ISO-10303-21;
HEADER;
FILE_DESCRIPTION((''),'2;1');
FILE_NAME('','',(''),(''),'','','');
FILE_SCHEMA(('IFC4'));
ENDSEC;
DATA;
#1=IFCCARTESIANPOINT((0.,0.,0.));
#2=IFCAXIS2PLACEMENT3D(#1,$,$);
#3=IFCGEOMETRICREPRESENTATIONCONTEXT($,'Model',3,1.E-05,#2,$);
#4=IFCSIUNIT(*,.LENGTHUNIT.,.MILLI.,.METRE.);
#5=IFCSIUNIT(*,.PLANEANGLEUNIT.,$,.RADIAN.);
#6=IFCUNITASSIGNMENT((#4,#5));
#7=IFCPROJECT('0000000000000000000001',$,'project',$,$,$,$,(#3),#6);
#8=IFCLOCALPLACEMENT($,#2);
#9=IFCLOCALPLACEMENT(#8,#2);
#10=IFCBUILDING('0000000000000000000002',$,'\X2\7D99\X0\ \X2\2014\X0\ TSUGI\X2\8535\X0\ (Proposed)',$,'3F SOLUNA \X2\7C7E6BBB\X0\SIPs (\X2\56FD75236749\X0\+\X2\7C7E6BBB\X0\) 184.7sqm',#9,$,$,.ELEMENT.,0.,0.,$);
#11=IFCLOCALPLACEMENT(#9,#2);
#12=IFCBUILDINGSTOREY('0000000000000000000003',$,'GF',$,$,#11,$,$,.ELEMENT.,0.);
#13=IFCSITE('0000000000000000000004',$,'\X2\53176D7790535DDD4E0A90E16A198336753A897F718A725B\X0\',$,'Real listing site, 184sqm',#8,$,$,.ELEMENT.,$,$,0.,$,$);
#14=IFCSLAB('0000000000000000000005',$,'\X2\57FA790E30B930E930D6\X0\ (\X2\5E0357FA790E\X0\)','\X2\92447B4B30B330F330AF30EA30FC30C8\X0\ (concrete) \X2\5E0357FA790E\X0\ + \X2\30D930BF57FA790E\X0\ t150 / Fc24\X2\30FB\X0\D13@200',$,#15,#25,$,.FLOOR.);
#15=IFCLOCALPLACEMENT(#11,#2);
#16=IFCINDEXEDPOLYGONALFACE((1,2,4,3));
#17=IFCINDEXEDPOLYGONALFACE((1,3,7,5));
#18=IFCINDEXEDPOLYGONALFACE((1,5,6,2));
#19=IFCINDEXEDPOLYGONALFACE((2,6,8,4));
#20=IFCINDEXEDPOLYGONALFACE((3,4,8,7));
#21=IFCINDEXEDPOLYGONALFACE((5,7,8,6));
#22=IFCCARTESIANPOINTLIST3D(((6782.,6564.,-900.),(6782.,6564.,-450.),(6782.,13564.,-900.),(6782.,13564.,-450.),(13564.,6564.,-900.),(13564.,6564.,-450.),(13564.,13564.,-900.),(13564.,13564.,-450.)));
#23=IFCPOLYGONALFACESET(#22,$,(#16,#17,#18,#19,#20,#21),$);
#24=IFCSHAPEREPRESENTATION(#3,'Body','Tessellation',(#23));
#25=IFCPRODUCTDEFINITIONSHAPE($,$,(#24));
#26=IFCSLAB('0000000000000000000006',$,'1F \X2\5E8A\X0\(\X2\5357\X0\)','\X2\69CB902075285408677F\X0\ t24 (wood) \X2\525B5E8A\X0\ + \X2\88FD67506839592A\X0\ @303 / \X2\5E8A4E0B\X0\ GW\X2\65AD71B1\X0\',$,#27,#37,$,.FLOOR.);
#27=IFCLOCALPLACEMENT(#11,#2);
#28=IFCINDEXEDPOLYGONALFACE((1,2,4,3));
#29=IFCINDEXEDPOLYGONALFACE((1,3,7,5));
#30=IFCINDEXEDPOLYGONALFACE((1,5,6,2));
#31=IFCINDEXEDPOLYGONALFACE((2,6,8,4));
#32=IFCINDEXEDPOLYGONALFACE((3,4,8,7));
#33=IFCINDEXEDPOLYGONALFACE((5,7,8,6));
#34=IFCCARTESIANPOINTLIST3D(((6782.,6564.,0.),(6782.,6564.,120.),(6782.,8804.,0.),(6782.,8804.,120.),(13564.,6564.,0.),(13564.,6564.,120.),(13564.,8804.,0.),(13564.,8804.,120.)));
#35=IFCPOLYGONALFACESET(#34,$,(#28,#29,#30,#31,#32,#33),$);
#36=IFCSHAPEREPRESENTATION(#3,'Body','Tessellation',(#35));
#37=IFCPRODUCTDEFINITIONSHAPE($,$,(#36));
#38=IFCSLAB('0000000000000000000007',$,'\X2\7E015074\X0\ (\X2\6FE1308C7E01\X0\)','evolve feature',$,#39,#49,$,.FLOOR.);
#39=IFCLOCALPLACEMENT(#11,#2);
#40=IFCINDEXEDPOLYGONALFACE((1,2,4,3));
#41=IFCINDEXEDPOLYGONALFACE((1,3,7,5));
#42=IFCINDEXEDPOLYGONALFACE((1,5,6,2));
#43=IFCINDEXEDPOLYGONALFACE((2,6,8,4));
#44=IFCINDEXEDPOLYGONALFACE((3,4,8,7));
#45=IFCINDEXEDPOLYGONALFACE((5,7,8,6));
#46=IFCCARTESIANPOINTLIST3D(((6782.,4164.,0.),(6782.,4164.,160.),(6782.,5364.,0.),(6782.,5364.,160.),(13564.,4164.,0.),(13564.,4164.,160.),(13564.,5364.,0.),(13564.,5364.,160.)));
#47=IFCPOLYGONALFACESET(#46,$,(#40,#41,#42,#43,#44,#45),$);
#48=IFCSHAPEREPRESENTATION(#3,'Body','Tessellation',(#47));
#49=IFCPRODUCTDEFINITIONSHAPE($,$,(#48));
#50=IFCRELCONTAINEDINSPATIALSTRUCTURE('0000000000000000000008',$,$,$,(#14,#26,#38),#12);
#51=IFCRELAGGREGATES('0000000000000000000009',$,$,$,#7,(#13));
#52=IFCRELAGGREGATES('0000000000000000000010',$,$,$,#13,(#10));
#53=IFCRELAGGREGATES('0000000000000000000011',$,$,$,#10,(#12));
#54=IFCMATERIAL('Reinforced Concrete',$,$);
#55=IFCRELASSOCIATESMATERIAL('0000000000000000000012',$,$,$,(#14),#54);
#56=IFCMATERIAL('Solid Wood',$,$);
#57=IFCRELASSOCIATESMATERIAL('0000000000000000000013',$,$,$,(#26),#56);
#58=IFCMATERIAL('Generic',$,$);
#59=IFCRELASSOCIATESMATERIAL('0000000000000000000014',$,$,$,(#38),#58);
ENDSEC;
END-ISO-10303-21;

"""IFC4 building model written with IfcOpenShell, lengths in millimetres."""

from ifc_helpers import new_model, si_unit, frame, frame_2d, origin, place, context, project, spatial, rectangle, extrude, material, element, save


model = new_model("IFC4")

# Units and contexts
model_context = context("Model", 3, precision=1e-05, world=origin())
ifc_project = project(units=[si_unit("LENGTHUNIT", "METRE", prefix="MILLI"), si_unit("PLANEANGLEUNIT", "RADIAN")], contexts=[model_context])

# Site, building, storey
site_placement = place(None, origin())
site = spatial("IfcSite", under=ifc_project, at=site_placement, Name="北海道川上郡標茶町西熊牛", ObjectType="Real listing site, 184sqm", CompositionType="ELEMENT", RefElevation=0.0)
building_placement = place(site_placement, origin())
building = spatial("IfcBuilding", under=site, at=building_placement, Name="継 — TSUGI蔵 (Proposed)", ObjectType="3F SOLUNA 籾殻SIPs (国産杉+籾殻) 184.7sqm", CompositionType="ELEMENT", ElevationOfRefHeight=0.0, ElevationOfTerrain=0.0)
storey_placement = place(building_placement, origin())
storey = spatial("IfcBuildingStorey", under=building, at=storey_placement, Name="GF", CompositionType="ELEMENT", Elevation=0.0)

# Slabs
ifc_material_1 = material(Name="Reinforced Concrete")
slab_1_placement = place(storey_placement, frame((3391.0, 3282.0, -450.0)))
element("IfcSlab", 1, at=slab_1_placement, inside=storey, material=ifc_material_1, Name="基礎スラブ (布基礎)", Description="鉄筋コンクリート (concrete) 布基礎 + ベタ基礎 t150 / Fc24・D13@200", PredefinedType="FLOOR", context=model_context, shape_type="SweptSolid", body=[
    extrude(rectangle(XDim=6782.0, YDim=7000.0, at=frame_2d((3391.0, 3500.0))), frame((3391.0, 3282.0, -450.0)), (0.0, 0.0, 1.0), 450.0),
])
ifc_material_2 = material(Name="Solid Wood")
slab_2_placement = place(storey_placement, frame((3391.0, 3282.0, 0.0)))
element("IfcSlab", 2, at=slab_2_placement, inside=storey, material=ifc_material_2, Name="1F 床(南)", Description="構造用合板 t24 (wood) 剛床 + 製材根太 @303 / 床下 GW断熱", PredefinedType="FLOOR", context=model_context, shape_type="SweptSolid", body=[
    extrude(rectangle(XDim=6782.0, YDim=2240.0, at=frame_2d((3391.0, 1120.0))), frame((3391.0, 3282.0, 0.0)), (0.0, 0.0, 1.0), 120.0),
])
ifc_material_3 = material(Name="Generic")
slab_3_placement = place(storey_placement, frame((3391.0, 2082.0, 0.0)))
element("IfcSlab", 3, at=slab_3_placement, inside=storey, material=ifc_material_3, Name="縁側 (濡れ縁)", Description="evolve feature", PredefinedType="FLOOR", context=model_context, shape_type="SweptSolid", body=[
    extrude(rectangle(XDim=6782.0, YDim=1200.0, at=frame_2d((3391.0, 600.0))), frame((3391.0, 2082.0, 0.0)), (0.0, 0.0, 1.0), 160.0),
])

save(model, "model.ifc")
